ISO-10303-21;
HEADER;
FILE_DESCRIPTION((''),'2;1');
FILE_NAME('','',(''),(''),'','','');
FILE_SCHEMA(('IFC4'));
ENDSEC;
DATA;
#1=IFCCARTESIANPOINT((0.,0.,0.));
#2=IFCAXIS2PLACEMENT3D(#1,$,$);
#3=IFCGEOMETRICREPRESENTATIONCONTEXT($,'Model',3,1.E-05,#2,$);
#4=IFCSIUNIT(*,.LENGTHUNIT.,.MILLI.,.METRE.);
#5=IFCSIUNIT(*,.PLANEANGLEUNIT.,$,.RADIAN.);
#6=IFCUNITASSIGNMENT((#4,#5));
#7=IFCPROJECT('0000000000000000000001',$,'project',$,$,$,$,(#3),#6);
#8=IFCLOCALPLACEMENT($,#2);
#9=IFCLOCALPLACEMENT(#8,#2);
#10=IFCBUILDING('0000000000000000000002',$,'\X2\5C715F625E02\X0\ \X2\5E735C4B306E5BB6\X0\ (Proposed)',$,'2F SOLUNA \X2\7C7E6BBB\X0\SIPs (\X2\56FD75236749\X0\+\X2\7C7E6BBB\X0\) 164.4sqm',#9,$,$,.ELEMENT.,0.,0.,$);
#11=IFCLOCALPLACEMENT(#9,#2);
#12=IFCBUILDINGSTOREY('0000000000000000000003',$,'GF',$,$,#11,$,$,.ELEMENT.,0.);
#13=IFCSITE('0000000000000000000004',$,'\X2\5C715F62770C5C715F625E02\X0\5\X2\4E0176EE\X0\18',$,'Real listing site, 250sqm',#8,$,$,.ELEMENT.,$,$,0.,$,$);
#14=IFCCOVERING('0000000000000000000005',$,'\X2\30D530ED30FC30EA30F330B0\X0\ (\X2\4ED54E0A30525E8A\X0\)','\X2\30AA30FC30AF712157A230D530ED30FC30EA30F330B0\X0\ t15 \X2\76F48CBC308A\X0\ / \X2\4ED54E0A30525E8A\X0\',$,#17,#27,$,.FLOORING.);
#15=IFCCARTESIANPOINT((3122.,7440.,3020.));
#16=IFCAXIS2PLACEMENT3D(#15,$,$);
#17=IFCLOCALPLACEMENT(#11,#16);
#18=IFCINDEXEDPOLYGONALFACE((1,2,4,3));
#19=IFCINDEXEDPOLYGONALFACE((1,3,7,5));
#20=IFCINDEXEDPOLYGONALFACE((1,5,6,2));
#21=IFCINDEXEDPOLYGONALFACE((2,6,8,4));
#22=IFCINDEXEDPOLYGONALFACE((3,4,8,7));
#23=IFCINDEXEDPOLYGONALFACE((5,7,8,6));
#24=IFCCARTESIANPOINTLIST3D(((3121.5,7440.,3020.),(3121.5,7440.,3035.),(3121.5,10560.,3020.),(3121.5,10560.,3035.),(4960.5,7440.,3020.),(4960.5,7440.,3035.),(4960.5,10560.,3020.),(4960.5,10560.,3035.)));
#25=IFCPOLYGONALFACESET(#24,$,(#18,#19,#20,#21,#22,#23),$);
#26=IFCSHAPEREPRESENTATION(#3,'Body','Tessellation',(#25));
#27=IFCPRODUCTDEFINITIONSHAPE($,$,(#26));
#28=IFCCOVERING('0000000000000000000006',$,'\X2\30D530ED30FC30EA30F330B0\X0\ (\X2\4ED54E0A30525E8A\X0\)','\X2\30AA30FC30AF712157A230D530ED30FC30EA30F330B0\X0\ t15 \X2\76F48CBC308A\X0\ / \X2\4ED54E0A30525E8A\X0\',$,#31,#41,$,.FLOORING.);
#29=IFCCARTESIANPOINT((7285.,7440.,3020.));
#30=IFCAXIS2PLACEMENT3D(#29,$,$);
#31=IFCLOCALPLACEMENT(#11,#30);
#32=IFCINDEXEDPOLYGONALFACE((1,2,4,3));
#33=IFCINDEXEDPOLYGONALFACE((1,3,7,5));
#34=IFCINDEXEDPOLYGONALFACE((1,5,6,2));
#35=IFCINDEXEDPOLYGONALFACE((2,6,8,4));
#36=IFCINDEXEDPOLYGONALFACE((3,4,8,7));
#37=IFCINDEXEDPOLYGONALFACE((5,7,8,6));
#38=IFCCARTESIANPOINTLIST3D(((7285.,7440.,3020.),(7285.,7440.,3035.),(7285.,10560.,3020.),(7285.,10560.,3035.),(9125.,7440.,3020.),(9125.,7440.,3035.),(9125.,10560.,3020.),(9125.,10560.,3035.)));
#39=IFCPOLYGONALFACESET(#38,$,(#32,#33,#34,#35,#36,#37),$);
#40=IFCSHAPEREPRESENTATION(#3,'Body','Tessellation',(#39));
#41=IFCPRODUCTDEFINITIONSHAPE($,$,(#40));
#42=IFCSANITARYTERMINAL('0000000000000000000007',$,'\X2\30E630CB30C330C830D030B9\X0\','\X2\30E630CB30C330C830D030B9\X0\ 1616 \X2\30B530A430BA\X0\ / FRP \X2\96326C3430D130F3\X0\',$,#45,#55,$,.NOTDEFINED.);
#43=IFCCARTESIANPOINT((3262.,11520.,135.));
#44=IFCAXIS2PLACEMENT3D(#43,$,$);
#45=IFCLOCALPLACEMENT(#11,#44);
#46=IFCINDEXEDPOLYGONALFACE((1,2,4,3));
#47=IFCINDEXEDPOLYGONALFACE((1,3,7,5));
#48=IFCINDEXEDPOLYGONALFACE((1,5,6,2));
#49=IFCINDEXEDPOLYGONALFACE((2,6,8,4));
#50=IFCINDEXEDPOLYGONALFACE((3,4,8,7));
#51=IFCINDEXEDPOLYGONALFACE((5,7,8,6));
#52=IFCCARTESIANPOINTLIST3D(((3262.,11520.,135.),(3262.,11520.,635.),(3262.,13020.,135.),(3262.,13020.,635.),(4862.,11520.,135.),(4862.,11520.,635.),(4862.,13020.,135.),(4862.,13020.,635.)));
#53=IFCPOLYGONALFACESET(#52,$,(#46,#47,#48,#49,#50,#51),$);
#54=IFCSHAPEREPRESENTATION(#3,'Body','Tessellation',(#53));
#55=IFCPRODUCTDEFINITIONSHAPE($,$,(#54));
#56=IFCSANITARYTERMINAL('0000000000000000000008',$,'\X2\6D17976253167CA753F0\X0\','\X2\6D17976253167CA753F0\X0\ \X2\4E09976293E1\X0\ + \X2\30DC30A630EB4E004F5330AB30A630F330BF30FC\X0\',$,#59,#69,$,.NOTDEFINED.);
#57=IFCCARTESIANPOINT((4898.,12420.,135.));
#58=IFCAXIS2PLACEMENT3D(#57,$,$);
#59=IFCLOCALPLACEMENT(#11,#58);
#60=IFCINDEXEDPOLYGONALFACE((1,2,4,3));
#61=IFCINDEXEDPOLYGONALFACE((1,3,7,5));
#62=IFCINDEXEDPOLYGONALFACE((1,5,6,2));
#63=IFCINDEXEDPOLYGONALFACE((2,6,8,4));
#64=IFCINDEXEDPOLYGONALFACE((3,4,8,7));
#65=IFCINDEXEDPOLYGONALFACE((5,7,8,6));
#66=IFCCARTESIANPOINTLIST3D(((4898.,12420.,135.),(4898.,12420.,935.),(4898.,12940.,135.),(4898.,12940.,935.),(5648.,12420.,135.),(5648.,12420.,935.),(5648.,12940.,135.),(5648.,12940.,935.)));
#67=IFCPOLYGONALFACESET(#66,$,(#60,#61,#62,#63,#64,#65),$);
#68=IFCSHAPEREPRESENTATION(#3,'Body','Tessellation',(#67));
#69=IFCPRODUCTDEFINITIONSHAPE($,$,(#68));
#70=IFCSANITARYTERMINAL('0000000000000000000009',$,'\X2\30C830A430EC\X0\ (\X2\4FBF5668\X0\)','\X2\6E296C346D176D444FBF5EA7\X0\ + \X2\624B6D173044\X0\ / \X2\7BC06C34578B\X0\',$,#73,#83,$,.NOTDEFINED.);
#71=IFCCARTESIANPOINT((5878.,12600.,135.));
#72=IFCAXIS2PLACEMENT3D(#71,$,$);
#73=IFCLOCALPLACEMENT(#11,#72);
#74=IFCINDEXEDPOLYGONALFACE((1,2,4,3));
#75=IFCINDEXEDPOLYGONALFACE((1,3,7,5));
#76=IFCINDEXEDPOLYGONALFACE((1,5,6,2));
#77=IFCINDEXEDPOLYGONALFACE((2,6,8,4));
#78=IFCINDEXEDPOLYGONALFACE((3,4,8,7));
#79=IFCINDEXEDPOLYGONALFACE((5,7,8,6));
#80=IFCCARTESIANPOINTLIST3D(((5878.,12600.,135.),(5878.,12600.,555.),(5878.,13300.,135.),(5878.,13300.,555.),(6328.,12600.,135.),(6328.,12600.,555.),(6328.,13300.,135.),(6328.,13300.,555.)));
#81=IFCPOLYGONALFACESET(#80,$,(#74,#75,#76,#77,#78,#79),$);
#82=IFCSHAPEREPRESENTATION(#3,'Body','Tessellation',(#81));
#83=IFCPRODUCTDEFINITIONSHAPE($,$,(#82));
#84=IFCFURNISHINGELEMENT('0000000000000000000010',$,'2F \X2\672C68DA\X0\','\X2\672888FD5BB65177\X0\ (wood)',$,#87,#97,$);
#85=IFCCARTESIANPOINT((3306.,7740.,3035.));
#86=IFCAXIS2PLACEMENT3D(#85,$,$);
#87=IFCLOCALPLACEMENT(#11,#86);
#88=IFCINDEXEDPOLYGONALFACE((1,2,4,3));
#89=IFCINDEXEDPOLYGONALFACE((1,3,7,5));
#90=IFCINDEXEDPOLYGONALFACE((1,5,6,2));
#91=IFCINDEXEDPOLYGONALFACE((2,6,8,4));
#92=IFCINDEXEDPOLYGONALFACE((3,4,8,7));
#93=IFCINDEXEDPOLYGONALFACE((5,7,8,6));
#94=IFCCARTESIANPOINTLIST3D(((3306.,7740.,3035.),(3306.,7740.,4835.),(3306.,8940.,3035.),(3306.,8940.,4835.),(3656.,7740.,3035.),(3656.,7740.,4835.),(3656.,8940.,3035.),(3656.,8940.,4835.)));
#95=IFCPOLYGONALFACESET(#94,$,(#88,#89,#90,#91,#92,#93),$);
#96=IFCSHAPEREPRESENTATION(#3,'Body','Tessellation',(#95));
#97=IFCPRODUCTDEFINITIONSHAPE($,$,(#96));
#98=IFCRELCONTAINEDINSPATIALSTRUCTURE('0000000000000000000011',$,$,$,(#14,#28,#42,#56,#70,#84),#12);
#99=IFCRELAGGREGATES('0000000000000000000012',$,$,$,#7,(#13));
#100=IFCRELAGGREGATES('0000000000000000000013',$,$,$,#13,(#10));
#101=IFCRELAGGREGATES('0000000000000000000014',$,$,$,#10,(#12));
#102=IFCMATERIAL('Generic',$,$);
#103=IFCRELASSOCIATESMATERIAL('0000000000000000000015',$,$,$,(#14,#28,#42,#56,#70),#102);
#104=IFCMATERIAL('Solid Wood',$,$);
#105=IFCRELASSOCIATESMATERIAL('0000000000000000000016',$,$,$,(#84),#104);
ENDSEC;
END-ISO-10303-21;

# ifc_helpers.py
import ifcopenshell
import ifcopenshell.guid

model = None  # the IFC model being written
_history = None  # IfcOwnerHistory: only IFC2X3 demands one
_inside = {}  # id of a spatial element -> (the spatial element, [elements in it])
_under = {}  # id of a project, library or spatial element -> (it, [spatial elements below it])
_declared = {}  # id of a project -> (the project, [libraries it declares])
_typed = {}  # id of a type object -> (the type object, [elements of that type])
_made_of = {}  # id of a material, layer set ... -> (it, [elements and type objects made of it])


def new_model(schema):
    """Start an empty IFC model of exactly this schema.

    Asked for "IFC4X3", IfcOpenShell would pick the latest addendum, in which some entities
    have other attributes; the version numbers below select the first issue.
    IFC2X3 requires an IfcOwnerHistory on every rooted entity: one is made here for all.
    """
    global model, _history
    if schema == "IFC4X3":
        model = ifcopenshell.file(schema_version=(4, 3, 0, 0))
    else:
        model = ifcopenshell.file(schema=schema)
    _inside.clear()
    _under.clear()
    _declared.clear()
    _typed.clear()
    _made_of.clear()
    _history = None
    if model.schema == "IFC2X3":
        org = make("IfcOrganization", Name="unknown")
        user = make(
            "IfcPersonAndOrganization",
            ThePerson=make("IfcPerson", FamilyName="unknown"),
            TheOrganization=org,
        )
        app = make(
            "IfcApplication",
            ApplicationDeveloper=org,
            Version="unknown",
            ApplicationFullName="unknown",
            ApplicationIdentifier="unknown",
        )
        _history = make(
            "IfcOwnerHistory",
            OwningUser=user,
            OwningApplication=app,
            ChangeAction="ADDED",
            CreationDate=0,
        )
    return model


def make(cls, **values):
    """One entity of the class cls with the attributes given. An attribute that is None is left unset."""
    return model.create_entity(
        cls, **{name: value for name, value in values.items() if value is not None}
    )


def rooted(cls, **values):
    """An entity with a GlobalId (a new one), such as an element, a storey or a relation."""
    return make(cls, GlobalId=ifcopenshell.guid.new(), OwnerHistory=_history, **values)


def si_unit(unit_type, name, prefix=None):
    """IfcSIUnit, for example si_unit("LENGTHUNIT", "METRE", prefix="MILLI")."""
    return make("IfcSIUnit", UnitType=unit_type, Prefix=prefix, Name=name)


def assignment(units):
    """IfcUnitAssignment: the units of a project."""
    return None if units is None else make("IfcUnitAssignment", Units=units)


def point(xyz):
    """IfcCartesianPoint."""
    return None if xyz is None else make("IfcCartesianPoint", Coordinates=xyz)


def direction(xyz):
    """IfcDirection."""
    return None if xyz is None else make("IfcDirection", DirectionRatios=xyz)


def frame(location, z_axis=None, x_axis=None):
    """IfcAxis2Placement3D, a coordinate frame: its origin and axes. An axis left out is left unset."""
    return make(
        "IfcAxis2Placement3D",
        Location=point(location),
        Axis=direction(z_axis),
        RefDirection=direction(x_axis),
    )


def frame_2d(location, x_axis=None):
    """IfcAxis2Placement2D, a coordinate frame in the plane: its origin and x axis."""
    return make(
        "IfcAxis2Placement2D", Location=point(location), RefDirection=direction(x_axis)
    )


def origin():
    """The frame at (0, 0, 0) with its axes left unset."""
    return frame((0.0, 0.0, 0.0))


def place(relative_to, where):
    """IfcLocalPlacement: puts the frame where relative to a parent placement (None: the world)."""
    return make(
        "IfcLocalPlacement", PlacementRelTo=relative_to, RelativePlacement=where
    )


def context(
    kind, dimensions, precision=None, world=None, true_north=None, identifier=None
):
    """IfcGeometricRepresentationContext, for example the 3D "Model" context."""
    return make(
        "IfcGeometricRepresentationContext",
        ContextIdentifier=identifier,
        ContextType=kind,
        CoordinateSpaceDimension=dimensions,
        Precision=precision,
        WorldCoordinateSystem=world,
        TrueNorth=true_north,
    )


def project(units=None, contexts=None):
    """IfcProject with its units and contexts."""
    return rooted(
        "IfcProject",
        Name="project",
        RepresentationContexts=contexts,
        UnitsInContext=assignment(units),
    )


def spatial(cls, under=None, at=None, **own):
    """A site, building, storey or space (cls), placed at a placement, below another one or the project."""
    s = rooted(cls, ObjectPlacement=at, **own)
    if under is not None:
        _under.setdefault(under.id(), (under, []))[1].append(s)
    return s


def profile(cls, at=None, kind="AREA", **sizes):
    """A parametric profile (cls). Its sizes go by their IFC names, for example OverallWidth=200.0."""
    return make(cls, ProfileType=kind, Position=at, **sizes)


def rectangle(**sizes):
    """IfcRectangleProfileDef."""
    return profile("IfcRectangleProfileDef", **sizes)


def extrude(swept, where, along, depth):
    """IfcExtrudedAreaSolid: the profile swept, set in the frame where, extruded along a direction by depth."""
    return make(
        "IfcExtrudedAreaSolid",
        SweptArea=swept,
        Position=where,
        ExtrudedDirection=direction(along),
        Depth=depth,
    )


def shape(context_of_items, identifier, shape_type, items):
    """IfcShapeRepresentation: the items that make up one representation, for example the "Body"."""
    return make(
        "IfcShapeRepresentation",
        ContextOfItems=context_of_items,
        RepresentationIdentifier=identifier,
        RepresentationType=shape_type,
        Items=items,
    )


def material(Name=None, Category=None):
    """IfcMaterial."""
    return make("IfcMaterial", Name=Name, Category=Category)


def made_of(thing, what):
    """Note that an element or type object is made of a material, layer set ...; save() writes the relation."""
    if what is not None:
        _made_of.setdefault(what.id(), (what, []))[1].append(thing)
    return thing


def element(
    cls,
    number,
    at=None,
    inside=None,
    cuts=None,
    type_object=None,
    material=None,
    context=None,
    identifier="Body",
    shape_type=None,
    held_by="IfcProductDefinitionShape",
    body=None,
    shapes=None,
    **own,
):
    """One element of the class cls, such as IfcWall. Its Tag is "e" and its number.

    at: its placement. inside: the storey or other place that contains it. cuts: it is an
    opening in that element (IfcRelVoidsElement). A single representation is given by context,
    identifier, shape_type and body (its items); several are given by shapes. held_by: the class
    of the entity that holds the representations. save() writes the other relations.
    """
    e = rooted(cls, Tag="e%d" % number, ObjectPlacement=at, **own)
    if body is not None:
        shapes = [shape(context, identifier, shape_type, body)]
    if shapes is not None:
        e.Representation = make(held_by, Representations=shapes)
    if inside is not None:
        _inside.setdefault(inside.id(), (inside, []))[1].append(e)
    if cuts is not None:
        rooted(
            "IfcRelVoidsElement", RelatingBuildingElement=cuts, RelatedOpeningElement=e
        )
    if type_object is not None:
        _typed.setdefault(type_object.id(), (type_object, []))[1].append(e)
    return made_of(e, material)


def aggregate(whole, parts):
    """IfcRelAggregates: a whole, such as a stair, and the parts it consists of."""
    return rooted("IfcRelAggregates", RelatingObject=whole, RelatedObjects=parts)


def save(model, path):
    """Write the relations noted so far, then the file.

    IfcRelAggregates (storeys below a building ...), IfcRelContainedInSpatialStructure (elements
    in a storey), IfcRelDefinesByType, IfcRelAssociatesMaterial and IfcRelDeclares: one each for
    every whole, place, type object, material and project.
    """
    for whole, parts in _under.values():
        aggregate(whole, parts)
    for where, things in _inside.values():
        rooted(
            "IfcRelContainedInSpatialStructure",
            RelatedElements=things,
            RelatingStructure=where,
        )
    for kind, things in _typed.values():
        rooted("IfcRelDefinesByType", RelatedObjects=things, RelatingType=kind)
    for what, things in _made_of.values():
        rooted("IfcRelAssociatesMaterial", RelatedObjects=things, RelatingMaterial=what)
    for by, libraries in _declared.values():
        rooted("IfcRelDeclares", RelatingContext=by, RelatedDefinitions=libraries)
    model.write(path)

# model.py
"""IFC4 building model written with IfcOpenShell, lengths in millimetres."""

from ifc_helpers import new_model, si_unit, frame, frame_2d, origin, place, context, project, spatial, rectangle, extrude, material, element, save


model = new_model("IFC4")

# Units and contexts
model_context = context("Model", 3, precision=1e-05, world=origin())
ifc_project = project(units=[si_unit("LENGTHUNIT", "METRE", prefix="MILLI"), si_unit("PLANEANGLEUNIT", "RADIAN")], contexts=[model_context])

# Site, building, storey
site_placement = place(None, origin())
site = spatial("IfcSite", under=ifc_project, at=site_placement, Name="山形県山形市5丁目18", ObjectType="Real listing site, 250sqm", CompositionType="ELEMENT", RefElevation=0.0)
building_placement = place(site_placement, origin())
building = spatial("IfcBuilding", under=site, at=building_placement, Name="山形市 平屋の家 (Proposed)", ObjectType="2F SOLUNA 籾殻SIPs (国産杉+籾殻) 164.4sqm", CompositionType="ELEMENT", ElevationOfRefHeight=0.0, ElevationOfTerrain=0.0)
storey_placement = place(building_placement, origin())
storey = spatial("IfcBuildingStorey", under=building, at=storey_placement, Name="GF", CompositionType="ELEMENT", Elevation=0.0)

# Shared definitions
ifc_material_1 = material(Name="Solid Wood")
ifc_material_2 = material(Name="Generic")

# Coverings
covering_1_placement = place(storey_placement, frame((3122.0, 7440.0, 3020.0)))
element("IfcCovering", 1, at=covering_1_placement, inside=storey, material=ifc_material_2, Name="フローリング (仕上げ床)", Description="オーク無垢フローリング t15 直貼り / 仕上げ床", PredefinedType="FLOORING", context=model_context, shape_type="SweptSolid", body=[
    extrude(rectangle(XDim=1839.0, YDim=3120.0, at=frame_2d((919.0, 1560.0))), frame((3122.0, 7440.0, 3020.0)), (0.0, 0.0, 1.0), 15.0),
])
covering_2_placement = place(storey_placement, frame((7285.0, 7440.0, 3020.0)))
element("IfcCovering", 2, at=covering_2_placement, inside=storey, material=ifc_material_2, Name="フローリング (仕上げ床)", Description="オーク無垢フローリング t15 直貼り / 仕上げ床", PredefinedType="FLOORING", context=model_context, shape_type="SweptSolid", body=[
    extrude(rectangle(XDim=1840.0, YDim=3120.0, at=frame_2d((920.0, 1560.0))), frame((7285.0, 7440.0, 3020.0)), (0.0, 0.0, 1.0), 15.0),
])

# Sanitary terminals
sanitary_terminal_1_placement = place(storey_placement, frame((3262.0, 11520.0, 135.0)))
element("IfcSanitaryTerminal", 3, at=sanitary_terminal_1_placement, inside=storey, material=ifc_material_2, Name="ユニットバス", Description="ユニットバス 1616 サイズ / FRP 防水パン", PredefinedType="NOTDEFINED", context=model_context, shape_type="SweptSolid", body=[
    extrude(rectangle(XDim=1600.0, YDim=1500.0, at=frame_2d((800.0, 750.0))), frame((3262.0, 11520.0, 135.0)), (0.0, 0.0, 1.0), 500.0),
])
sanitary_terminal_2_placement = place(storey_placement, frame((4898.0, 12420.0, 135.0)))
element("IfcSanitaryTerminal", 4, at=sanitary_terminal_2_placement, inside=storey, material=ifc_material_2, Name="洗面化粧台", Description="洗面化粧台 三面鏡 + ボウル一体カウンター", PredefinedType="NOTDEFINED", context=model_context, shape_type="SweptSolid", body=[
    extrude(rectangle(XDim=750.0, YDim=520.0, at=frame_2d((375.0, 260.0))), frame((4898.0, 12420.0, 135.0)), (0.0, 0.0, 1.0), 800.0),
])
sanitary_terminal_3_placement = place(storey_placement, frame((5878.0, 12600.0, 135.0)))
element("IfcSanitaryTerminal", 5, at=sanitary_terminal_3_placement, inside=storey, material=ifc_material_2, Name="トイレ (便器)", Description="温水洗浄便座 + 手洗い / 節水型", PredefinedType="NOTDEFINED", context=model_context, shape_type="SweptSolid", body=[
    extrude(rectangle(XDim=450.0, YDim=700.0, at=frame_2d((225.0, 350.0))), frame((5878.0, 12600.0, 135.0)), (0.0, 0.0, 1.0), 420.0),
])

# Furnishing element
furnishing_placement = place(storey_placement, frame((3306.0, 7740.0, 3035.0)))
element("IfcFurnishingElement", 6, at=furnishing_placement, inside=storey, material=ifc_material_1, Name="2F 本棚", Description="木製家具 (wood)", context=model_context, shape_type="SweptSolid", body=[
    extrude(rectangle(XDim=350.0, YDim=1200.0, at=frame_2d((175.0, 600.0))), frame((3306.0, 7740.0, 3035.0)), (0.0, 0.0, 1.0), 1800.0),
])

save(model, "model.ifc")
